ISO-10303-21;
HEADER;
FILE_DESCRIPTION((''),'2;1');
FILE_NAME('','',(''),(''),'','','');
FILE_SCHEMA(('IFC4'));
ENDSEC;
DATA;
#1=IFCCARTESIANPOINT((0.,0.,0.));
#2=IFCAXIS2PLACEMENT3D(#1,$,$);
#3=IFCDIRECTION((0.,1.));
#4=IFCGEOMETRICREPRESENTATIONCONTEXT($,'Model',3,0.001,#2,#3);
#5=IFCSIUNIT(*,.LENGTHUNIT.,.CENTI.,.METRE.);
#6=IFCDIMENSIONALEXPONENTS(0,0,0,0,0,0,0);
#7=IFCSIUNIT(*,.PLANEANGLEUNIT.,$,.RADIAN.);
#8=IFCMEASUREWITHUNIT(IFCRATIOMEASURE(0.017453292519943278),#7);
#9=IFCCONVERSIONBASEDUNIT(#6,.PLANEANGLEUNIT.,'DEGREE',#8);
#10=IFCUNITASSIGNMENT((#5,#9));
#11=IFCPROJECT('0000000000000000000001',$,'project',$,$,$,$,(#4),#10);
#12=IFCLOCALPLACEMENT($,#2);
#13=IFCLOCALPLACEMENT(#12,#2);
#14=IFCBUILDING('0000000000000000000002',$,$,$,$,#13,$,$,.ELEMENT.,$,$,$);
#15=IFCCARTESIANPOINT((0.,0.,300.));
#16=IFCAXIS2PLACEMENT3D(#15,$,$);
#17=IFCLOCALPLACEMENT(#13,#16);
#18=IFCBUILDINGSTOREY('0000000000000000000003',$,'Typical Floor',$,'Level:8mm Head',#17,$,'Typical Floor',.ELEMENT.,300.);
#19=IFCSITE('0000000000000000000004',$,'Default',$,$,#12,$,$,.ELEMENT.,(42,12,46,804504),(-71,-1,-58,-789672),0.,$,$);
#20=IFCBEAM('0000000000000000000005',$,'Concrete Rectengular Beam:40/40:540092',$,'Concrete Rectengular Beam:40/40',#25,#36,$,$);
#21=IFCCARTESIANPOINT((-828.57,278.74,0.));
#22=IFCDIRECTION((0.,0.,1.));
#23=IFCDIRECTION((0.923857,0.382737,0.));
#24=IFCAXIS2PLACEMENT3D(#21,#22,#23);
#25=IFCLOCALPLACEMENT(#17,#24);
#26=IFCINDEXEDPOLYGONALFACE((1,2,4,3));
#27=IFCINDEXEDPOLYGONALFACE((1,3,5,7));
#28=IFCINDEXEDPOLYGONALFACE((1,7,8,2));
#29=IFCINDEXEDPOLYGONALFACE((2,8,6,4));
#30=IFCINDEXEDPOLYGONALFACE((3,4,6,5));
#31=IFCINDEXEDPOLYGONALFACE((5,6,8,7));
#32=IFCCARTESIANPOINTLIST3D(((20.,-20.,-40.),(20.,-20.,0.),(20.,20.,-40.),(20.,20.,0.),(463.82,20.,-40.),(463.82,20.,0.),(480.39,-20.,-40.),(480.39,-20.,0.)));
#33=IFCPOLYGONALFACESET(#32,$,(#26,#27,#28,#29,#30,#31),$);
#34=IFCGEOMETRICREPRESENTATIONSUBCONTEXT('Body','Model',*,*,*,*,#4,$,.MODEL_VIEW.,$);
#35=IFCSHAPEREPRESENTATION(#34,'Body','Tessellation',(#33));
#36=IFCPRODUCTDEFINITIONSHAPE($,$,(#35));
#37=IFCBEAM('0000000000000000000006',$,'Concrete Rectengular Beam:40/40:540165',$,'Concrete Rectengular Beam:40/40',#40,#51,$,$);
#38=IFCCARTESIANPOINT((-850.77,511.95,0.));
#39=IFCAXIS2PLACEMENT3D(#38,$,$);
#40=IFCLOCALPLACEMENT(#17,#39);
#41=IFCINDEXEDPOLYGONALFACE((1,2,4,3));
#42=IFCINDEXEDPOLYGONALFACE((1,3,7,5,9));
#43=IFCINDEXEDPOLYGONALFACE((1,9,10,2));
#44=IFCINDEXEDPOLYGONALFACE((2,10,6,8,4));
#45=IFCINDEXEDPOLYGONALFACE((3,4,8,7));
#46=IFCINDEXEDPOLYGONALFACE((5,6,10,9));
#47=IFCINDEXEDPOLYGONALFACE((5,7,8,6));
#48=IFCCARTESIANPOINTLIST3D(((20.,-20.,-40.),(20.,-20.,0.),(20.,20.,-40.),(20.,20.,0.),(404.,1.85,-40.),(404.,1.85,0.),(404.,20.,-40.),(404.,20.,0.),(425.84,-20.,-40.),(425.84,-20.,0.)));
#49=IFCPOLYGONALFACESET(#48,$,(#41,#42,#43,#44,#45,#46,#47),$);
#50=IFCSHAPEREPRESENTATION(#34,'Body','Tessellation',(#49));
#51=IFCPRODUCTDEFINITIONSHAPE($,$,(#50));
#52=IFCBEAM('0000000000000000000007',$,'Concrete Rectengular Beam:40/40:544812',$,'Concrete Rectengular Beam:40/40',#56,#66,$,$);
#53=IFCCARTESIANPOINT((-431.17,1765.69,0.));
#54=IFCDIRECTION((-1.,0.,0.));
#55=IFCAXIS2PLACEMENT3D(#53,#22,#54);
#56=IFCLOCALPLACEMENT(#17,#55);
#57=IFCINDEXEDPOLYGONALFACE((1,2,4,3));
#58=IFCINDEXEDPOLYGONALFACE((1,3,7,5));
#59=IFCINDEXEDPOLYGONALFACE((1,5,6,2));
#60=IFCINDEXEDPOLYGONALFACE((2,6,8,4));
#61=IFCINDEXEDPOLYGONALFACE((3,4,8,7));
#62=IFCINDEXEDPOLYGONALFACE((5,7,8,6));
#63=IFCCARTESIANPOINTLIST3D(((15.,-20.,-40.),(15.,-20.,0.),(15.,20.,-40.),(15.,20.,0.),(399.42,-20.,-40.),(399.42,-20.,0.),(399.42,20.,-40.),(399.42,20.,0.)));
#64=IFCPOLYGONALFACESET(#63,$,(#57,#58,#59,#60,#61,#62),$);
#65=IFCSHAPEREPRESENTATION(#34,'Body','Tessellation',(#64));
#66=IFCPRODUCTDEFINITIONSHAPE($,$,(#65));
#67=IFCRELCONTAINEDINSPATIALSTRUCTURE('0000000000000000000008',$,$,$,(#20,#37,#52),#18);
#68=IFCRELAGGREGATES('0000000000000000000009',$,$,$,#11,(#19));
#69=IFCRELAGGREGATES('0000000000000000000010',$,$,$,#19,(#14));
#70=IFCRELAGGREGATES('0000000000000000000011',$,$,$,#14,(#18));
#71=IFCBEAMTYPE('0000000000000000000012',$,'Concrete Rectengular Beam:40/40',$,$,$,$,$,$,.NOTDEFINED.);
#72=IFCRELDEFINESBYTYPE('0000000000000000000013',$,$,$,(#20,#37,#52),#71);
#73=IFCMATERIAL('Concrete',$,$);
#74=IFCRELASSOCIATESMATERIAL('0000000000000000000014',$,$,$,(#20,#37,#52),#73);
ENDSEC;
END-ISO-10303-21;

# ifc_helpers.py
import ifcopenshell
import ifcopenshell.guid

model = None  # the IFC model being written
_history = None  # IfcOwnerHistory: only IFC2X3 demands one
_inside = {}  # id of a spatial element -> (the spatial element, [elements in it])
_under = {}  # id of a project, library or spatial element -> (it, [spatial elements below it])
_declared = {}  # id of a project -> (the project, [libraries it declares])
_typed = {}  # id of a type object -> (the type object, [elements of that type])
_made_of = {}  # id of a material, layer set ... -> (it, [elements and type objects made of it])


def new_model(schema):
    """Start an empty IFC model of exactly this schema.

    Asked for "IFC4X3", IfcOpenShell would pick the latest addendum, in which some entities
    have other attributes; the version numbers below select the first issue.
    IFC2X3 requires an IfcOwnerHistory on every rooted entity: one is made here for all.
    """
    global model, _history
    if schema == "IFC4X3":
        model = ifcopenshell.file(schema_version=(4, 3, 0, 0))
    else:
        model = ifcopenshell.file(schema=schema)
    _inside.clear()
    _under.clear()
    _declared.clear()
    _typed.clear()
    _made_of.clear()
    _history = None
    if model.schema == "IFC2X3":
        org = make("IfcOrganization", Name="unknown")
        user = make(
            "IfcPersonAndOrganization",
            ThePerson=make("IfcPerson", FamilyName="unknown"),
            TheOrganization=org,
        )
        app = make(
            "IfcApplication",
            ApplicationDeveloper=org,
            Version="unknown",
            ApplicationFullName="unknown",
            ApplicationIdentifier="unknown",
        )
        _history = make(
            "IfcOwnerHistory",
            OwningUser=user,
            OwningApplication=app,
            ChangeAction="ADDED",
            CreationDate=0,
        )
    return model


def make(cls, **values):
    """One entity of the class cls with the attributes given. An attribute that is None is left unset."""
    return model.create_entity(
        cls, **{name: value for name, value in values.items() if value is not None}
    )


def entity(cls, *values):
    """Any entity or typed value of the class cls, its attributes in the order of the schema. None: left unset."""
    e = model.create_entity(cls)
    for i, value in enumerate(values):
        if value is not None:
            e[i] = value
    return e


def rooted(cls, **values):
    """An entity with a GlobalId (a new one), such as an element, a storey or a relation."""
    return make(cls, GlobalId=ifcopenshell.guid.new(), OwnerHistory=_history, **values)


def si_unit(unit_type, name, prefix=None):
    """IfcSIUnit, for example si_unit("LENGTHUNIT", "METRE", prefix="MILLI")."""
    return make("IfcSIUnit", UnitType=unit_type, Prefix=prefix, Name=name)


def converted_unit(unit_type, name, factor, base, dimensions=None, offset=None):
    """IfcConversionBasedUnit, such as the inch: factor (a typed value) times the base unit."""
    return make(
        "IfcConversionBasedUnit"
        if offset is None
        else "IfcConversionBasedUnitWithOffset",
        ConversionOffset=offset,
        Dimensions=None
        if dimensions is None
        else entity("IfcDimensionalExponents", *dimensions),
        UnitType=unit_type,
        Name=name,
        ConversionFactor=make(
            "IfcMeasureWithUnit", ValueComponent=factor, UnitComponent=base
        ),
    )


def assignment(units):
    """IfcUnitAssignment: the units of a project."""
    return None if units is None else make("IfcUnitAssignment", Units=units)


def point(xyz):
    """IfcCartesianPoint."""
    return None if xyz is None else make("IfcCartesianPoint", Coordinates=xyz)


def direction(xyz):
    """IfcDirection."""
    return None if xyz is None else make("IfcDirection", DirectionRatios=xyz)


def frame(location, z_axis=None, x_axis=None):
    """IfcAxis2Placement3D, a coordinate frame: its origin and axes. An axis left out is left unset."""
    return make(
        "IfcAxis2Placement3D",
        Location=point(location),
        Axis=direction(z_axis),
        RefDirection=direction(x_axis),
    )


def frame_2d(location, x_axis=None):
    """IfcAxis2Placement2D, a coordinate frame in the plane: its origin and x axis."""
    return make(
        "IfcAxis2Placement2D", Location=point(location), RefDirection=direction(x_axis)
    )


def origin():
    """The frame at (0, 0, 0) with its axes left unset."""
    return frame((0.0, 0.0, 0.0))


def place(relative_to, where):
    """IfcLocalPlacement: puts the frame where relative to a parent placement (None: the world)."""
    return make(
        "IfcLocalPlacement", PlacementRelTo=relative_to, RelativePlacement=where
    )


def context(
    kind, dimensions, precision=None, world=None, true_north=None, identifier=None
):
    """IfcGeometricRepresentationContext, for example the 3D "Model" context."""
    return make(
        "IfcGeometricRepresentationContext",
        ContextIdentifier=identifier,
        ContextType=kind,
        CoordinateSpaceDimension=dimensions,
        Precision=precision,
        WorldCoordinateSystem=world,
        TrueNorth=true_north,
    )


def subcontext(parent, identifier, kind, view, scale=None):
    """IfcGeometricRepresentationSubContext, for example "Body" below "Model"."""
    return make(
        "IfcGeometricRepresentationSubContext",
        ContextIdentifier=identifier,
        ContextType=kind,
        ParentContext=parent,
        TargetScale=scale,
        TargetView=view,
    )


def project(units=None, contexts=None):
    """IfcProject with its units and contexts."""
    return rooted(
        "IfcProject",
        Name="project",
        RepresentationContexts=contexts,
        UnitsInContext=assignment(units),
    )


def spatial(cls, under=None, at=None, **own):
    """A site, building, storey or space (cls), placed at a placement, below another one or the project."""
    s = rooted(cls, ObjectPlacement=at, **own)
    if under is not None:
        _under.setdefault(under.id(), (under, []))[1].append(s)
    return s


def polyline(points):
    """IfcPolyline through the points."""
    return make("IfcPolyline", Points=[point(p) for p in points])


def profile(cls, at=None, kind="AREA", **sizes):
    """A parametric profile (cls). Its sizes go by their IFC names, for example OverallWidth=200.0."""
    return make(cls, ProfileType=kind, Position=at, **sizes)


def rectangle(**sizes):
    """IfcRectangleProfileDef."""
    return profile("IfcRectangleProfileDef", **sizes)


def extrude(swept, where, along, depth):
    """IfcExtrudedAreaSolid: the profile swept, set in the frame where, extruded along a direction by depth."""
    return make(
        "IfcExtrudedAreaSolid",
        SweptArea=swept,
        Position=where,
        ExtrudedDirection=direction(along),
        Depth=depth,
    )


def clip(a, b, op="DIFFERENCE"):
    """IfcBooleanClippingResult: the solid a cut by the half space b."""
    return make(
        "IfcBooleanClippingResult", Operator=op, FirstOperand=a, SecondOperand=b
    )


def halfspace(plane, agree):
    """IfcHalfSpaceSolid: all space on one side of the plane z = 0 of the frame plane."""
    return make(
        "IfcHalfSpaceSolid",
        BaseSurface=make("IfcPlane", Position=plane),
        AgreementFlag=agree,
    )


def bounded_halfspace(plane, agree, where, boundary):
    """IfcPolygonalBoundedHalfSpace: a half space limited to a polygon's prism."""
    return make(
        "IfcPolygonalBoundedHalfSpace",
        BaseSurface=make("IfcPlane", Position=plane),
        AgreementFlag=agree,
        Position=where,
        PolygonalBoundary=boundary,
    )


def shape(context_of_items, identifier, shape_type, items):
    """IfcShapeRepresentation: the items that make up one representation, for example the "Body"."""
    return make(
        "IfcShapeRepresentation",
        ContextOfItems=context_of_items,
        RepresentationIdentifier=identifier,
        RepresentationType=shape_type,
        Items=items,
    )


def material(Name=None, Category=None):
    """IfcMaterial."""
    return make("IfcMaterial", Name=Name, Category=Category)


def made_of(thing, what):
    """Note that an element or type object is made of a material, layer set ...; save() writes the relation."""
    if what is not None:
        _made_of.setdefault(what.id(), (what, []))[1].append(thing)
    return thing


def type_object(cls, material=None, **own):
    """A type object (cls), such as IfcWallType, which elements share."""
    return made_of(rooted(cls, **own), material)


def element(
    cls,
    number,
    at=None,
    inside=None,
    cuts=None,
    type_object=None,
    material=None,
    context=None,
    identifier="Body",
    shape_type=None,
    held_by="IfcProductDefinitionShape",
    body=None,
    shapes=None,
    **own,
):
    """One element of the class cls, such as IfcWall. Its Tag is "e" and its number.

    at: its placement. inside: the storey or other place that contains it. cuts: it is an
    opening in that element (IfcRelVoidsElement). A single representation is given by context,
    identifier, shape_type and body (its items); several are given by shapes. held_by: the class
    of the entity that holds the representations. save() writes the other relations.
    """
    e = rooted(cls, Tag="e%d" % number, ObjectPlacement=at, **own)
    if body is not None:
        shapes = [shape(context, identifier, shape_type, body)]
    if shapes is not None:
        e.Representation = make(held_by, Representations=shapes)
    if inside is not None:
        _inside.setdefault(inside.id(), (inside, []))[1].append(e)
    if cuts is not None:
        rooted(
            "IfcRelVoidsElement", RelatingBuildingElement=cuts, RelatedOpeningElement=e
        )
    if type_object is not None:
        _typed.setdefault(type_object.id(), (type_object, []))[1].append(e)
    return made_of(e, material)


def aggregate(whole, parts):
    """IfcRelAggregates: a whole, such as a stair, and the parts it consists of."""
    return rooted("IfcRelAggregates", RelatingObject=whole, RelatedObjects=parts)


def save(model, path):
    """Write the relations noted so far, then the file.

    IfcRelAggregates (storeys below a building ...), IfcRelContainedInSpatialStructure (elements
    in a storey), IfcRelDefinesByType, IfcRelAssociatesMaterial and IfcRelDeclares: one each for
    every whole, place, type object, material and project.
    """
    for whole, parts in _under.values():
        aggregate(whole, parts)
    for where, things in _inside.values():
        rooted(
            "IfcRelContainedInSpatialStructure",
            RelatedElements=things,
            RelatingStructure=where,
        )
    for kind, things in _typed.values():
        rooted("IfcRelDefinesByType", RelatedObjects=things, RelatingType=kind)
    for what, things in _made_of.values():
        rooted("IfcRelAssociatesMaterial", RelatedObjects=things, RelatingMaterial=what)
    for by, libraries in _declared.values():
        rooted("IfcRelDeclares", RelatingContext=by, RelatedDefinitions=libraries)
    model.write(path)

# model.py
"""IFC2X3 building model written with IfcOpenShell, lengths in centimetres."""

from ifc_helpers import new_model, entity, si_unit, converted_unit, direction, frame, frame_2d, origin, place, context, subcontext, project, spatial, polyline, rectangle, extrude, clip, halfspace, bounded_halfspace, material, type_object, element, save


model = new_model("IFC2X3")

# Units and contexts
model_context = context("Model", 3, precision=0.001, world=origin(), true_north=direction((0.0, 1.0)))
body_context = subcontext(model_context, "Body", "Model", "MODEL_VIEW")
ifc_project = project(units=[si_unit("LENGTHUNIT", "METRE", prefix="CENTI"), converted_unit("PLANEANGLEUNIT", "DEGREE", entity("IfcRatioMeasure", 0.017453292519943278), si_unit("PLANEANGLEUNIT", "RADIAN"), dimensions=[0, 0, 0, 0, 0, 0, 0])], contexts=[model_context])

# Site, building, storey
site_placement = place(None, origin())
site = spatial("IfcSite", under=ifc_project, at=site_placement, Name="Default", CompositionType="ELEMENT", RefLatitude=(42, 12, 46, 804504), RefLongitude=(-71, -1, -58, -789672), RefElevation=0.0)
building_placement = place(site_placement, origin())
building = spatial("IfcBuilding", under=site, at=building_placement, CompositionType="ELEMENT")
storey_placement = place(building_placement, frame((0.0, 0.0, 300.0)))
storey = spatial("IfcBuildingStorey", under=building, at=storey_placement, Name="Typical Floor", ObjectType="Level:8mm Head", LongName="Typical Floor", CompositionType="ELEMENT", Elevation=300.0)

# Beams
ifc_material = material(Name="Concrete")
beam_type_1 = type_object("IfcBeamType", Name="Concrete Rectengular Beam:40/40", PredefinedType="NOTDEFINED")
beam_1_placement = place(storey_placement, frame((-828.57, 278.74, 0.0), z_axis=(0.0, 0.0, 1.0), x_axis=(0.923857, 0.382737, 0.0)))
element("IfcBeam", 1, at=beam_1_placement, inside=storey, type_object=beam_type_1, material=ifc_material, Name="Concrete Rectengular Beam:40/40:540092", ObjectType="Concrete Rectengular Beam:40/40", context=body_context, shape_type="SweptSolid", body=[
    clip(extrude(rectangle(XDim=40.0, YDim=40.0, at=frame_2d((0.0, 0.0), x_axis=(1.0, 0.0))), frame((20.0, 0.0, -20.0), z_axis=(1.0, 0.0, 0.0), x_axis=(0.0, 0.0, -1.0)), (0.0, 0.0, 1.0), 460.39), halfspace(frame((536.6, -155.72, -300.0), z_axis=(0.923902, 0.38263, 0.0), x_axis=(0.38263, -0.923902, 0.0)), False)),
])
beam_2_placement = place(storey_placement, frame((-850.77, 511.95, 0.0)))
element("IfcBeam", 2, at=beam_2_placement, inside=storey, type_object=beam_type_1, material=ifc_material, Name="Concrete Rectengular Beam:40/40:540165", ObjectType="Concrete Rectengular Beam:40/40", context=body_context, shape_type="SweptSolid", body=[
    clip(clip(extrude(rectangle(XDim=40.0, YDim=40.0, at=frame_2d((0.0, 0.0), x_axis=(1.0, 0.0))), frame((20.0, 0.0, -20.0), z_axis=(1.0, 0.0, 0.0), x_axis=(0.0, 0.0, -1.0)), (0.0, 0.0, 1.0), 405.84), bounded_halfspace(frame((577.54, -171.69, -300.0), z_axis=(0.707107, 0.707107, 0.0), x_axis=(0.707107, -0.707107, 0.0)), False, frame((20.0, 0.0, -20.0), z_axis=(1.0, 0.0, 0.0), x_axis=(0.0, 0.0, -1.0)), polyline([(20.0, 1.85), (-20.0, 1.85), (-20.0, -20.0), (0.0, -20.0), (20.0, -20.0), (20.0, 1.85)]))), bounded_halfspace(frame((404.0, 22.41, -300.0), z_axis=(1.0, 0.0, 0.0), x_axis=(0.0, -1.0, 0.0)), False, frame((20.0, 0.0, -20.0), z_axis=(1.0, 0.0, 0.0), x_axis=(0.0, 0.0, -1.0)), polyline([(-20.0, 1.85), (20.0, 1.85), (20.0, 20.0), (0.0, 20.0), (-20.0, 20.0), (-20.0, 1.85)]))),
])
beam_3_placement = place(storey_placement, frame((-431.17, 1765.69, 0.0), z_axis=(0.0, 0.0, 1.0), x_axis=(-1.0, 0.0, 0.0)))
element("IfcBeam", 3, at=beam_3_placement, inside=storey, type_object=beam_type_1, material=ifc_material, Name="Concrete Rectengular Beam:40/40:544812", ObjectType="Concrete Rectengular Beam:40/40", context=body_context, shape_type="SweptSolid", body=[
    extrude(rectangle(XDim=40.0, YDim=40.0, at=frame_2d((0.0, 0.0), x_axis=(1.0, 0.0))), frame((15.0, 0.0, -20.0), z_axis=(1.0, 0.0, 0.0), x_axis=(0.0, 0.0, -1.0)), (0.0, 0.0, 1.0), 384.42),
])

save(model, "model.ifc")
